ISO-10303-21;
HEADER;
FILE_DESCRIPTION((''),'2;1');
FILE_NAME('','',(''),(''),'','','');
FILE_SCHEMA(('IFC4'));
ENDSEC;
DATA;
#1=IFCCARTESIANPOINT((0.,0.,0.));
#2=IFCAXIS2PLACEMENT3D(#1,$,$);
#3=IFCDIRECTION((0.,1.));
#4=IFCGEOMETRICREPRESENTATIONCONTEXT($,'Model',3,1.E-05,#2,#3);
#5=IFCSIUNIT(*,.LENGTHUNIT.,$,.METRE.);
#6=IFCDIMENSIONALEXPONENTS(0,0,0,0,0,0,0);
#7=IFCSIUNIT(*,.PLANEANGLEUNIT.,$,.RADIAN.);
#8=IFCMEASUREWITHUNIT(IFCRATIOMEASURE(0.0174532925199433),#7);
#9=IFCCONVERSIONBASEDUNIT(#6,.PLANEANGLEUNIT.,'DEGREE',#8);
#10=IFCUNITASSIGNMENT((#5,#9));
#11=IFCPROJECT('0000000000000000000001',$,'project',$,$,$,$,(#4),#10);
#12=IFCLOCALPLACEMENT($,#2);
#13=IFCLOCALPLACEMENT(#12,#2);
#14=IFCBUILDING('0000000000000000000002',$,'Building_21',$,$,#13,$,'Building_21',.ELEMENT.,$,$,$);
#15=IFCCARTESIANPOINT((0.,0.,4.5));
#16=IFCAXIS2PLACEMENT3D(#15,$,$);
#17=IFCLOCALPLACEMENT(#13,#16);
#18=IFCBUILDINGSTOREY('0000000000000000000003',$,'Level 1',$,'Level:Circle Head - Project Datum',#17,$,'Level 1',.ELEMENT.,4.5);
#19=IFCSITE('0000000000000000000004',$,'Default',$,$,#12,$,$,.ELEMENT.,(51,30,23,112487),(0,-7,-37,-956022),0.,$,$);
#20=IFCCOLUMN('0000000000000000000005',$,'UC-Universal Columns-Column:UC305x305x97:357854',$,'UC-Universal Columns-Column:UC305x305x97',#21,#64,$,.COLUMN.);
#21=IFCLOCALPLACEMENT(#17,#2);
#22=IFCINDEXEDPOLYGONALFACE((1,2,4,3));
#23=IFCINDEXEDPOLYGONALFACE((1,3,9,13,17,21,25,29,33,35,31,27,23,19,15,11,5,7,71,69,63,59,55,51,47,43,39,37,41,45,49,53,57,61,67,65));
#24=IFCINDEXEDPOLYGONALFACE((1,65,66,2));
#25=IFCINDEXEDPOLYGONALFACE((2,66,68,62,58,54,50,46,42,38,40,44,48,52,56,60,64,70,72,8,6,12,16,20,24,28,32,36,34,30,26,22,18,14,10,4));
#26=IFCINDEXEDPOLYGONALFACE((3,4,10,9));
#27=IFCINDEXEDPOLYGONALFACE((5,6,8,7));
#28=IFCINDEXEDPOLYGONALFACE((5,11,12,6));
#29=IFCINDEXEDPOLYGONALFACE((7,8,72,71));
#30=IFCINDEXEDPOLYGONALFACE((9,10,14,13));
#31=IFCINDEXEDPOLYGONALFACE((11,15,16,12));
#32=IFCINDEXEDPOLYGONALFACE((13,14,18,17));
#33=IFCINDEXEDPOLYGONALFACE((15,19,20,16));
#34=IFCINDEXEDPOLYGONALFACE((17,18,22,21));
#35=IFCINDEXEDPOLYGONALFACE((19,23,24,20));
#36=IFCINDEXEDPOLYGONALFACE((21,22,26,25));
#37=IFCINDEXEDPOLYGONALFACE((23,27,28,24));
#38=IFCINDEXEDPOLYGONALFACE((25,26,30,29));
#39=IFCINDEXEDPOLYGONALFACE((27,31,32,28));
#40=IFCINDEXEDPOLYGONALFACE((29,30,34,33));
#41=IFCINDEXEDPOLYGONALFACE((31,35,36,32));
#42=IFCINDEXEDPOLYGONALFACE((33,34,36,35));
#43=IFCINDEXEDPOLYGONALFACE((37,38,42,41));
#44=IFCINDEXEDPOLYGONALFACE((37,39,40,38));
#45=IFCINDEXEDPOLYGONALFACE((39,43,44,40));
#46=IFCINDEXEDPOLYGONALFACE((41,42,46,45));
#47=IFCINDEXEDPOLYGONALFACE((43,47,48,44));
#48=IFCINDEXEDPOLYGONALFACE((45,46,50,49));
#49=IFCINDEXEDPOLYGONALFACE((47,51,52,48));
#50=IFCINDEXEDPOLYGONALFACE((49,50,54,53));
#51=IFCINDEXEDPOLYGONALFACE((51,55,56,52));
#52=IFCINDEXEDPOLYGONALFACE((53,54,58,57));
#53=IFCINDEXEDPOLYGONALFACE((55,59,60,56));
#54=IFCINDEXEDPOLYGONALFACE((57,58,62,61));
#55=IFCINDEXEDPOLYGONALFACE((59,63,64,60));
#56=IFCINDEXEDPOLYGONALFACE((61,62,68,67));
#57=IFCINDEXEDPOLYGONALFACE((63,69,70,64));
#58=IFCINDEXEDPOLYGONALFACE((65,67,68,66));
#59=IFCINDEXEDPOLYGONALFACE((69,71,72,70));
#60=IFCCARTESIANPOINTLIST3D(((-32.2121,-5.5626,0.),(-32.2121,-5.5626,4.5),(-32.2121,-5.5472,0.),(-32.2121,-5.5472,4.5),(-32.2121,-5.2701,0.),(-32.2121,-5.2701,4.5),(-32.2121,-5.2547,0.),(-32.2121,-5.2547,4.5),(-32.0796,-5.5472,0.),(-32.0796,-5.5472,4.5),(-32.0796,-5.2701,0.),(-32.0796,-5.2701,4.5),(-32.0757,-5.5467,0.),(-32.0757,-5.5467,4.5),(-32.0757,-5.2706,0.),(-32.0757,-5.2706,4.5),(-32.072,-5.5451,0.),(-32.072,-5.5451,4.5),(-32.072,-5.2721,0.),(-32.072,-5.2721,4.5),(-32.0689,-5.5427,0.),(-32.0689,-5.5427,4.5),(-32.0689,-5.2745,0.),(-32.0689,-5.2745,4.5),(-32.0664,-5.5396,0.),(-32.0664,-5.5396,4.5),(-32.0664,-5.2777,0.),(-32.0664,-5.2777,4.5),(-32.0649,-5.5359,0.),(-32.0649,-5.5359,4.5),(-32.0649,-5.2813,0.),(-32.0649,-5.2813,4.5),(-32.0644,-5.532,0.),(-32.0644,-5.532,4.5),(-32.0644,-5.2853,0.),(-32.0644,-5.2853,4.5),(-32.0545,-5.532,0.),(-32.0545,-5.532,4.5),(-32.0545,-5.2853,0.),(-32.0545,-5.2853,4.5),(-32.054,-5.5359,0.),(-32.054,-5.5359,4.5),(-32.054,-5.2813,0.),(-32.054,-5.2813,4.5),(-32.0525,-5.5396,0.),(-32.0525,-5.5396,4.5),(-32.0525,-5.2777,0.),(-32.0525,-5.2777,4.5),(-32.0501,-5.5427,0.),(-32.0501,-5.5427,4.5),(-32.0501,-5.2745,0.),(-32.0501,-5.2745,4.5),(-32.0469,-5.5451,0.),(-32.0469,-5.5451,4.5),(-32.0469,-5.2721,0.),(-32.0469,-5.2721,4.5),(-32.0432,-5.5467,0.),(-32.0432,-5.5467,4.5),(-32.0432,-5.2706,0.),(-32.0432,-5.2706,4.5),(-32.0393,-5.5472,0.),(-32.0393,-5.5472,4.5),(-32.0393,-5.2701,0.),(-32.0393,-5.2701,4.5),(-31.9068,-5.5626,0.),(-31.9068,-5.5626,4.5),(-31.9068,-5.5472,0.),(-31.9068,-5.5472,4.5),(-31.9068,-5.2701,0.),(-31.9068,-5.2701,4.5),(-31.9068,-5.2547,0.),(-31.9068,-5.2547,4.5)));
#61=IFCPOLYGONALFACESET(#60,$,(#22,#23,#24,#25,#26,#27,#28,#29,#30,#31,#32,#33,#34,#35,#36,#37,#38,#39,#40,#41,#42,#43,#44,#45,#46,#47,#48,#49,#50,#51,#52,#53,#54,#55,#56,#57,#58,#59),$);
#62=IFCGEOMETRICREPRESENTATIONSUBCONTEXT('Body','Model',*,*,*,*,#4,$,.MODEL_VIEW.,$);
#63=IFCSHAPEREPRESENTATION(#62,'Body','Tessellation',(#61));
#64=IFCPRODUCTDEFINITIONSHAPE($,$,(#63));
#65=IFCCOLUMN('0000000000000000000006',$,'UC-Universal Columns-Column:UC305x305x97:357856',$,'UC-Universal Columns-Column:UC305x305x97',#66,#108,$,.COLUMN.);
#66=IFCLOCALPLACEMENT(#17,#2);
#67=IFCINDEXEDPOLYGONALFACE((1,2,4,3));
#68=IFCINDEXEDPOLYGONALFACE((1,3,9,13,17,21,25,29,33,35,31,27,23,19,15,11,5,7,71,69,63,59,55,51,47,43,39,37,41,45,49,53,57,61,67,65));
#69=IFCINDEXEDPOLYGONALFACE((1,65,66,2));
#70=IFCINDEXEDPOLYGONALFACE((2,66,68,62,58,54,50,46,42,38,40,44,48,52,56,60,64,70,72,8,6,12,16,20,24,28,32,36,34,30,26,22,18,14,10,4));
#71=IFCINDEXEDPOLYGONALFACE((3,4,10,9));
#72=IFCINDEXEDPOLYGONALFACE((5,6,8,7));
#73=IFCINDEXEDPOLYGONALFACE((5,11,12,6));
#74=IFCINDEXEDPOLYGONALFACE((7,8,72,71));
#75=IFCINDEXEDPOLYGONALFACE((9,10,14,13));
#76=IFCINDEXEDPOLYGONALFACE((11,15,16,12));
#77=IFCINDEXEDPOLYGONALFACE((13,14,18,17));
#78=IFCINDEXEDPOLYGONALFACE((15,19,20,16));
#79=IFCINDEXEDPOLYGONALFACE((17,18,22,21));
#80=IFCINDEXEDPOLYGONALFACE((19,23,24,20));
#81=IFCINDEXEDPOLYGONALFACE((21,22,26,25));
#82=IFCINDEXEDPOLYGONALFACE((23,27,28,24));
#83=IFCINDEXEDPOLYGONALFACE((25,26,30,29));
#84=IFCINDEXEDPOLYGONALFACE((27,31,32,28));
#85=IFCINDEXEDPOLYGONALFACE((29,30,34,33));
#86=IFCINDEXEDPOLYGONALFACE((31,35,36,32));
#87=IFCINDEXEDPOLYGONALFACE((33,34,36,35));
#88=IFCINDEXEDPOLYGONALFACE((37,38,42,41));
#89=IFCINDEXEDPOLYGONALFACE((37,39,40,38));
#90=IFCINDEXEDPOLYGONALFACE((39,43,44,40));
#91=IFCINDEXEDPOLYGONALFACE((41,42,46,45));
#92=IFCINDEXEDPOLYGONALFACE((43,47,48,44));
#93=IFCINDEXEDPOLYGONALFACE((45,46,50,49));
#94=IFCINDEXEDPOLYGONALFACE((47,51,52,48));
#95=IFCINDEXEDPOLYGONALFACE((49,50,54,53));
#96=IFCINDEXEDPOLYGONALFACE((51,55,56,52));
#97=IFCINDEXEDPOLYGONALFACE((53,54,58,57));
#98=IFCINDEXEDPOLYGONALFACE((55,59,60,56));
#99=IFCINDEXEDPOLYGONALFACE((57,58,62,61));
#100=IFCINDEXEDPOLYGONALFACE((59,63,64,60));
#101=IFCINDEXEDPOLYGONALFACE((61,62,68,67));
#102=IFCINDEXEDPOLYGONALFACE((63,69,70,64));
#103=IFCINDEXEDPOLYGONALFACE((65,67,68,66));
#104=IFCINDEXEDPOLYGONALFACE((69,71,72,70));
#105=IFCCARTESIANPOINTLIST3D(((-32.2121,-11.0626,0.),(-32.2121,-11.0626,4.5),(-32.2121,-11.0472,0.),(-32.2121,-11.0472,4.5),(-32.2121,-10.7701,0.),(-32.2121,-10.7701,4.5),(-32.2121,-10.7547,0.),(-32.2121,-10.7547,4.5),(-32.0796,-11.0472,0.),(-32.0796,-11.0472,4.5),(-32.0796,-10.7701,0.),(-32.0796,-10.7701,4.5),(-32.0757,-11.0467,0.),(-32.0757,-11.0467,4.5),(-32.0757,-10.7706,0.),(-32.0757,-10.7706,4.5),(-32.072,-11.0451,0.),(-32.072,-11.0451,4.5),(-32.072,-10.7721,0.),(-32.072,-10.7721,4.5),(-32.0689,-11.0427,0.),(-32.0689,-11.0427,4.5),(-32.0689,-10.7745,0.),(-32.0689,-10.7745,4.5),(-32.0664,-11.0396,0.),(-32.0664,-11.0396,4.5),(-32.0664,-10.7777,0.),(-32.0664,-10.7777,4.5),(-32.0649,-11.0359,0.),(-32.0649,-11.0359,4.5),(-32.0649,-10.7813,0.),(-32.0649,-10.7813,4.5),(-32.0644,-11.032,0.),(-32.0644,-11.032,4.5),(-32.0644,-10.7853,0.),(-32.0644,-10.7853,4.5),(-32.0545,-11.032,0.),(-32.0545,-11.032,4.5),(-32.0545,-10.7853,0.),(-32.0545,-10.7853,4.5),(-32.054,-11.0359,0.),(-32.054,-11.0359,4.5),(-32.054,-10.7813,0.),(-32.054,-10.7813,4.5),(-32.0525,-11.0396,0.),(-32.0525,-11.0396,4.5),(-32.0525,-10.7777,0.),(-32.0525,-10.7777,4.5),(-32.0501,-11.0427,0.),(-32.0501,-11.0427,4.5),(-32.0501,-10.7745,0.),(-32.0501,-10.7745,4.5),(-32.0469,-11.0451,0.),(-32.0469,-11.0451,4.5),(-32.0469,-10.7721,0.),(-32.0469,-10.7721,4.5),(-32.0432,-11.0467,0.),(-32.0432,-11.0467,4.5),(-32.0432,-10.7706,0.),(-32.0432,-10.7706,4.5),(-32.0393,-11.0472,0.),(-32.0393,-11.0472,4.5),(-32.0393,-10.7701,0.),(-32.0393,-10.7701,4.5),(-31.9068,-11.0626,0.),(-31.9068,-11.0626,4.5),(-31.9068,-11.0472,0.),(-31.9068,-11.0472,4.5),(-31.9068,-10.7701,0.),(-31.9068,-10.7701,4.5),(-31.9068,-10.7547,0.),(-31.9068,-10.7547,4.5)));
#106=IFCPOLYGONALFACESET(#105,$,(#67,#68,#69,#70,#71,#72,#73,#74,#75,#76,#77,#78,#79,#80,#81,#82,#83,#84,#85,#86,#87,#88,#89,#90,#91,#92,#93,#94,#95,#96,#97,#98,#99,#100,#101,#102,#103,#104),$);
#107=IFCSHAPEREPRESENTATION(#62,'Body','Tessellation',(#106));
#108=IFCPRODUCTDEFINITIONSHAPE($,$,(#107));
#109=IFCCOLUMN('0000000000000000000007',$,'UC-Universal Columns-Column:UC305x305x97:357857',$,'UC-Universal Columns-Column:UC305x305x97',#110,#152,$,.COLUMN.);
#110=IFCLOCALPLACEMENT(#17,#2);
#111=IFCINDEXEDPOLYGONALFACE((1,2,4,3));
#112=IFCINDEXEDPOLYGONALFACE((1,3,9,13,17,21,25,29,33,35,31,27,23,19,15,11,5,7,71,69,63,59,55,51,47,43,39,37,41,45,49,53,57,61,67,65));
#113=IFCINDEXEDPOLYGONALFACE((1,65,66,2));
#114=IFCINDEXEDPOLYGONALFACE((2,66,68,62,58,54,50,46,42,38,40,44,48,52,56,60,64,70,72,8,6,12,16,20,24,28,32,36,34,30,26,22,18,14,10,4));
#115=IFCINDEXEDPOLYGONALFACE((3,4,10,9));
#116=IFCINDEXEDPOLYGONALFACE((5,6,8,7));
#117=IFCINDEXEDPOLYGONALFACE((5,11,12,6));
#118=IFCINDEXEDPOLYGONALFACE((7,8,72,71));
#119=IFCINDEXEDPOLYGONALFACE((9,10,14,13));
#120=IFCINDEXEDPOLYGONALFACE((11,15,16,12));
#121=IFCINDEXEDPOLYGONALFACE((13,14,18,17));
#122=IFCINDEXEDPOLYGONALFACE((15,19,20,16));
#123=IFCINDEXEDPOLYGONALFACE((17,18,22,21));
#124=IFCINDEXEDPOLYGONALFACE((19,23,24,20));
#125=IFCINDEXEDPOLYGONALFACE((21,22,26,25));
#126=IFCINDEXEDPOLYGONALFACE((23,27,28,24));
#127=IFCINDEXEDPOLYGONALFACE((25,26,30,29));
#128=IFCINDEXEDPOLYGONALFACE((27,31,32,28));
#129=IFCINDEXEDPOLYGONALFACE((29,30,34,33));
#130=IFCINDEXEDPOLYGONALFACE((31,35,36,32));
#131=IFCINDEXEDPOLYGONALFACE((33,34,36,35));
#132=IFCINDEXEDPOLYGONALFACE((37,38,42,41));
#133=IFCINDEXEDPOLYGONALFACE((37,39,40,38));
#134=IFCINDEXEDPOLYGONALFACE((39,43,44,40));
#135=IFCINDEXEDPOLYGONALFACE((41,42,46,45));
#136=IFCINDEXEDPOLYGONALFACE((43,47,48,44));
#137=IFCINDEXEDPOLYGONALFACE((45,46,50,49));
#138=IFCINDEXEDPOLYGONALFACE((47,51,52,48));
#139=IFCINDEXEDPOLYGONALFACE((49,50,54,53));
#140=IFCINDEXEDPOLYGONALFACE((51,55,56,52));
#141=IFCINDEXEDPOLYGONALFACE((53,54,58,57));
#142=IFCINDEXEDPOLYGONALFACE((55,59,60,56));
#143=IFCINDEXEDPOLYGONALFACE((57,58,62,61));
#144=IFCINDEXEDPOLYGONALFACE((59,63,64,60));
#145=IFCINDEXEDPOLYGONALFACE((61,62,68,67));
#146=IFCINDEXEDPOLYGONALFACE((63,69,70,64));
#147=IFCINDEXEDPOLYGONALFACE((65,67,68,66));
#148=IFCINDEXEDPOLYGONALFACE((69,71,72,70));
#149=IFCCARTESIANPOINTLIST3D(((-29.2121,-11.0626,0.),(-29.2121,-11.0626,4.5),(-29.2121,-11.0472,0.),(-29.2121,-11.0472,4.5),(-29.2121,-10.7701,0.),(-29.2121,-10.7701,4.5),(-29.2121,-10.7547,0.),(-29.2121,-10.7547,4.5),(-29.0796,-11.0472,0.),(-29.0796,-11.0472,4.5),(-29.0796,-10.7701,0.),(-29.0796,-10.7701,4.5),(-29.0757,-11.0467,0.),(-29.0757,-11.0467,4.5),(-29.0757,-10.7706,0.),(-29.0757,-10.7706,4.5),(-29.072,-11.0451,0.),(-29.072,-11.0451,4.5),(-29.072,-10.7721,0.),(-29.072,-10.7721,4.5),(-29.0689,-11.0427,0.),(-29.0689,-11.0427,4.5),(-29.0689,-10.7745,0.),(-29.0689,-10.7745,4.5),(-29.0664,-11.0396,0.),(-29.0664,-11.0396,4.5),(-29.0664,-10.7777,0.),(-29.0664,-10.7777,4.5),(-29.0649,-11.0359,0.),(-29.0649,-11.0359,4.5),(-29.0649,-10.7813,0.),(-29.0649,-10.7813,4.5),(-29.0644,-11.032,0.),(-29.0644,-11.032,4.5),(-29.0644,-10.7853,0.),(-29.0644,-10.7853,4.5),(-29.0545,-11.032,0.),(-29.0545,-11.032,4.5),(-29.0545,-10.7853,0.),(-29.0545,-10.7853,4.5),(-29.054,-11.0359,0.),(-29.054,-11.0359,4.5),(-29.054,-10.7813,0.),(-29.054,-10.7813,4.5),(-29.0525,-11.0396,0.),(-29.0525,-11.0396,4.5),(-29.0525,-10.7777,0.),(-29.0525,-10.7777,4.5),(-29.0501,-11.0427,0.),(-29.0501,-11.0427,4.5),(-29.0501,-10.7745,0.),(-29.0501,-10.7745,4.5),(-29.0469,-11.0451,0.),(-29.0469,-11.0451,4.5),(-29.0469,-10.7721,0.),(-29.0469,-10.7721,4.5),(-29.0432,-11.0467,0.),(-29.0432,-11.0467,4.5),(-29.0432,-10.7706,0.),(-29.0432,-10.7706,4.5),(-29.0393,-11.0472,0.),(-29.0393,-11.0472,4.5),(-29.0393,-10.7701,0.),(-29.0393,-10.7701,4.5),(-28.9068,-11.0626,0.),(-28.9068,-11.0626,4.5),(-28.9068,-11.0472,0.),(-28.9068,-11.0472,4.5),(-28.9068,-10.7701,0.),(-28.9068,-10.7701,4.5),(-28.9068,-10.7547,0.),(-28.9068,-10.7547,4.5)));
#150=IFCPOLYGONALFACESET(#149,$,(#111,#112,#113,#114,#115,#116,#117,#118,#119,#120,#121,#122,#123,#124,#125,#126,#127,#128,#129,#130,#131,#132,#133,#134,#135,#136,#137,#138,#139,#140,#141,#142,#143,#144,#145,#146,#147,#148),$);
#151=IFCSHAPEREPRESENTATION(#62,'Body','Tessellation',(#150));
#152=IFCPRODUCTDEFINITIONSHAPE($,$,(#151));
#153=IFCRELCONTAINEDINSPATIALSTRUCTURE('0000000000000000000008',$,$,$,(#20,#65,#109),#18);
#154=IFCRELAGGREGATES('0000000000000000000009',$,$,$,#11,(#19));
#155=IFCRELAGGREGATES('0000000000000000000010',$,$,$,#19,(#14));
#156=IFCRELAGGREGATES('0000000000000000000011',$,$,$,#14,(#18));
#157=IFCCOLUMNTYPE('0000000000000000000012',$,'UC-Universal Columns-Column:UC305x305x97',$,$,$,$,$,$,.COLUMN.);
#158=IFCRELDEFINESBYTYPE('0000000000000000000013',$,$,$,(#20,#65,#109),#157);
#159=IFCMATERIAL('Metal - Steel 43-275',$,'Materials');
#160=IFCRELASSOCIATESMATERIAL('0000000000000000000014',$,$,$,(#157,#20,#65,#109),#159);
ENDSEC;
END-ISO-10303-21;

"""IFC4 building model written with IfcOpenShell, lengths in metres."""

from ifc_helpers import new_model, entity, si_unit, converted_unit, direction, frame, frame_2d, origin, place, context, subcontext, project, spatial, polyline, circle_curve, parameter, trimmed, segment, composite_curve, i_section, outline, extrude, source, transform, mapped, material, material_profile, profile_set, profile_usage, type_object, type_shapes, element, save


model = new_model("IFC4")

# Units and contexts
model_context = context("Model", 3, precision=1e-05, world=origin(), true_north=direction((0.0, 1.0)))
body_context = subcontext(model_context, "Body", "Model", "MODEL_VIEW")
ifc_project = project(units=[si_unit("LENGTHUNIT", "METRE"), converted_unit("PLANEANGLEUNIT", "DEGREE", entity("IfcRatioMeasure", 0.0174532925199433), si_unit("PLANEANGLEUNIT", "RADIAN"), dimensions=[0, 0, 0, 0, 0, 0, 0])], contexts=[model_context])

# Site, building, storey
site_placement = place(None, origin())
site = spatial("IfcSite", under=ifc_project, at=site_placement, Name="Default", CompositionType="ELEMENT", RefLatitude=(51, 30, 23, 112487), RefLongitude=(0, -7, -37, -956022), RefElevation=0.0)
building_placement = place(site_placement, origin())
building = spatial("IfcBuilding", under=site, at=building_placement, Name="Building_21", LongName="Building_21", CompositionType="ELEMENT")
storey_placement = place(building_placement, frame((0.0, 0.0, 4.5)))
storey = spatial("IfcBuildingStorey", under=building, at=storey_placement, Name="Level 1", ObjectType="Level:Circle Head - Project Datum", LongName="Level 1", CompositionType="ELEMENT", Elevation=4.5)

# Columns
ifc_material_1 = material(Name="Metal - Steel 43-275", Category="Materials")
ifc_material_profile_1 = material_profile(ifc_material_1, outline(composite_curve([segment(polyline([(-0.1527, 0.154, 0.0), (0.1527, 0.154, 0.0)]), True, "CONTINUOUS"), segment(polyline([(0.1527, 0.154, 0.0), (0.1527, 0.1386, 0.0)]), True, "CONTINUOUS"), segment(polyline([(0.1527, 0.1386, 0.0), (0.0201, 0.1386, 0.0)]), True, "CONTINUOUS"), segment(trimmed(circle_curve(frame((0.0201, 0.1234, 0.0)), 0.0152), [parameter(90.0)], [parameter(180.0)], True, "PARAMETER"), True, "CONTINUOUS"), segment(polyline([(0.0049, 0.1234, 0.0), (0.0049, -0.1234, 0.0)]), True, "CONTINUOUS"), segment(trimmed(circle_curve(frame((0.0201, -0.1234, 0.0)), 0.0152), [parameter(180.0)], [parameter(270.0)], True, "PARAMETER"), True, "CONTINUOUS"), segment(polyline([(0.0201, -0.1386, 0.0), (0.1527, -0.1386, 0.0)]), True, "CONTINUOUS"), segment(polyline([(0.1527, -0.1386, 0.0), (0.1527, -0.154, 0.0)]), True, "CONTINUOUS"), segment(polyline([(0.1527, -0.154, 0.0), (-0.1527, -0.154, 0.0)]), True, "CONTINUOUS"), segment(polyline([(-0.1527, -0.154, 0.0), (-0.1527, -0.1386, 0.0)]), True, "CONTINUOUS"), segment(polyline([(-0.1527, -0.1386, 0.0), (-0.0201, -0.1386, 0.0)]), True, "CONTINUOUS"), segment(trimmed(circle_curve(frame((-0.0201, -0.1234, 0.0)), 0.0152), [parameter(270.0)], [parameter(0.0)], True, "PARAMETER"), True, "CONTINUOUS"), segment(polyline([(-0.0049, -0.1234, 0.0), (-0.005, 0.1234, 0.0)]), True, "CONTINUOUS"), segment(trimmed(circle_curve(frame((-0.0201, 0.1234, 0.0)), 0.0152), [parameter(0.0)], [parameter(90.0)], True, "PARAMETER"), True, "CONTINUOUS"), segment(polyline([(-0.0201, 0.1386, 0.0), (-0.1527, 0.1386, 0.0)]), True, "CONTINUOUS"), segment(polyline([(-0.1527, 0.1386, 0.0), (-0.1527, 0.154, 0.0)]), True, "CONTINUOUS")], self_intersect=False), kind="CURVE"), Name="UC305x305x97")
ifc_material_profile_2 = material_profile(ifc_material_1, outline(composite_curve([segment(polyline([(0.1527, 0.154, 0.0), (0.1527, 0.1386, 0.0)]), True, "CONTINUOUS"), segment(polyline([(0.1527, 0.1386, 0.0), (0.0049, 0.1386, 0.0)]), True, "CONTINUOUS"), segment(polyline([(0.0049, 0.1386, 0.0), (0.0049, -0.1386, 0.0)]), True, "CONTINUOUS"), segment(polyline([(0.0049, -0.1386, 0.0), (0.1527, -0.1386, 0.0)]), True, "CONTINUOUS"), segment(polyline([(0.1527, -0.1386, 0.0), (0.1527, -0.154, 0.0)]), True, "CONTINUOUS"), segment(polyline([(0.1527, -0.154, 0.0), (-0.1527, -0.154, 0.0)]), True, "CONTINUOUS"), segment(polyline([(-0.1527, -0.154, 0.0), (-0.1527, -0.1386, 0.0)]), True, "CONTINUOUS"), segment(polyline([(-0.1527, -0.1386, 0.0), (-0.005, -0.1386, 0.0)]), True, "CONTINUOUS"), segment(polyline([(-0.005, -0.1386, 0.0), (-0.005, 0.1386, 0.0)]), True, "CONTINUOUS"), segment(polyline([(-0.005, 0.1386, 0.0), (-0.1527, 0.1386, 0.0)]), True, "CONTINUOUS"), segment(polyline([(-0.1527, 0.1386, 0.0), (-0.1527, 0.154, 0.0)]), True, "CONTINUOUS"), segment(polyline([(-0.1527, 0.154, 0.0), (0.1527, 0.154, 0.0)]), True, "CONTINUOUS")], self_intersect=False), kind="CURVE"), Name="UC305x305x97")
ifc_profile_set_1 = profile_set([ifc_material_profile_1, ifc_material_profile_2], Name="UC305x305x97")
ifc_profile_usage_1 = profile_usage(ifc_profile_set_1)
column_type = type_object("IfcColumnType", Name="UC-Universal Columns-Column:UC305x305x97", PredefinedType="COLUMN", material=ifc_profile_set_1)
shared_shape_1 = source(origin(), body_context, "Body", "SweptSolid", [
    extrude(i_section(OverallWidth=0.3053, OverallDepth=0.3079, WebThickness=0.0099, FlangeThickness=0.0154, FilletRadius=0.0152, at=frame_2d((0.0, 0.0), x_axis=(0.0, 1.0))), frame((0.0, 0.0, 4.5), z_axis=(0.0, 0.0, 1.0), x_axis=(0.0, -1.0, 0.0)), (0.0, 0.0, 1.0), 4.5),
])
type_shapes(column_type, [shared_shape_1])
column_1_placement = place(storey_placement, frame((-32.0595, -5.4086, -4.5)))
element("IfcColumn", 1, at=column_1_placement, inside=storey, type_object=column_type, material=ifc_profile_usage_1, Name="UC-Universal Columns-Column:UC305x305x97:357854", ObjectType="UC-Universal Columns-Column:UC305x305x97", PredefinedType="COLUMN", context=body_context, shape_type="MappedRepresentation", body=[
    mapped(shared_shape_1, transform((0.0, 0.0, 0.0), scale=1.0)),
])
ifc_profile_usage_2 = profile_usage(ifc_profile_set_1)
column_2_placement = place(storey_placement, frame((-32.0595, -10.9086, -4.5)))
element("IfcColumn", 2, at=column_2_placement, inside=storey, type_object=column_type, material=ifc_profile_usage_2, Name="UC-Universal Columns-Column:UC305x305x97:357856", ObjectType="UC-Universal Columns-Column:UC305x305x97", PredefinedType="COLUMN", context=body_context, shape_type="MappedRepresentation", body=[
    mapped(shared_shape_1, transform((0.0, 0.0, 0.0), scale=1.0)),
])
ifc_profile_usage_3 = profile_usage(ifc_profile_set_1)
column_3_placement = place(storey_placement, frame((-29.0595, -10.9086, -4.5)))
element("IfcColumn", 3, at=column_3_placement, inside=storey, type_object=column_type, material=ifc_profile_usage_3, Name="UC-Universal Columns-Column:UC305x305x97:357857", ObjectType="UC-Universal Columns-Column:UC305x305x97", PredefinedType="COLUMN", context=body_context, shape_type="MappedRepresentation", body=[
    mapped(shared_shape_1, transform((0.0, 0.0, 0.0), scale=1.0)),
])

save(model, "model.ifc")
